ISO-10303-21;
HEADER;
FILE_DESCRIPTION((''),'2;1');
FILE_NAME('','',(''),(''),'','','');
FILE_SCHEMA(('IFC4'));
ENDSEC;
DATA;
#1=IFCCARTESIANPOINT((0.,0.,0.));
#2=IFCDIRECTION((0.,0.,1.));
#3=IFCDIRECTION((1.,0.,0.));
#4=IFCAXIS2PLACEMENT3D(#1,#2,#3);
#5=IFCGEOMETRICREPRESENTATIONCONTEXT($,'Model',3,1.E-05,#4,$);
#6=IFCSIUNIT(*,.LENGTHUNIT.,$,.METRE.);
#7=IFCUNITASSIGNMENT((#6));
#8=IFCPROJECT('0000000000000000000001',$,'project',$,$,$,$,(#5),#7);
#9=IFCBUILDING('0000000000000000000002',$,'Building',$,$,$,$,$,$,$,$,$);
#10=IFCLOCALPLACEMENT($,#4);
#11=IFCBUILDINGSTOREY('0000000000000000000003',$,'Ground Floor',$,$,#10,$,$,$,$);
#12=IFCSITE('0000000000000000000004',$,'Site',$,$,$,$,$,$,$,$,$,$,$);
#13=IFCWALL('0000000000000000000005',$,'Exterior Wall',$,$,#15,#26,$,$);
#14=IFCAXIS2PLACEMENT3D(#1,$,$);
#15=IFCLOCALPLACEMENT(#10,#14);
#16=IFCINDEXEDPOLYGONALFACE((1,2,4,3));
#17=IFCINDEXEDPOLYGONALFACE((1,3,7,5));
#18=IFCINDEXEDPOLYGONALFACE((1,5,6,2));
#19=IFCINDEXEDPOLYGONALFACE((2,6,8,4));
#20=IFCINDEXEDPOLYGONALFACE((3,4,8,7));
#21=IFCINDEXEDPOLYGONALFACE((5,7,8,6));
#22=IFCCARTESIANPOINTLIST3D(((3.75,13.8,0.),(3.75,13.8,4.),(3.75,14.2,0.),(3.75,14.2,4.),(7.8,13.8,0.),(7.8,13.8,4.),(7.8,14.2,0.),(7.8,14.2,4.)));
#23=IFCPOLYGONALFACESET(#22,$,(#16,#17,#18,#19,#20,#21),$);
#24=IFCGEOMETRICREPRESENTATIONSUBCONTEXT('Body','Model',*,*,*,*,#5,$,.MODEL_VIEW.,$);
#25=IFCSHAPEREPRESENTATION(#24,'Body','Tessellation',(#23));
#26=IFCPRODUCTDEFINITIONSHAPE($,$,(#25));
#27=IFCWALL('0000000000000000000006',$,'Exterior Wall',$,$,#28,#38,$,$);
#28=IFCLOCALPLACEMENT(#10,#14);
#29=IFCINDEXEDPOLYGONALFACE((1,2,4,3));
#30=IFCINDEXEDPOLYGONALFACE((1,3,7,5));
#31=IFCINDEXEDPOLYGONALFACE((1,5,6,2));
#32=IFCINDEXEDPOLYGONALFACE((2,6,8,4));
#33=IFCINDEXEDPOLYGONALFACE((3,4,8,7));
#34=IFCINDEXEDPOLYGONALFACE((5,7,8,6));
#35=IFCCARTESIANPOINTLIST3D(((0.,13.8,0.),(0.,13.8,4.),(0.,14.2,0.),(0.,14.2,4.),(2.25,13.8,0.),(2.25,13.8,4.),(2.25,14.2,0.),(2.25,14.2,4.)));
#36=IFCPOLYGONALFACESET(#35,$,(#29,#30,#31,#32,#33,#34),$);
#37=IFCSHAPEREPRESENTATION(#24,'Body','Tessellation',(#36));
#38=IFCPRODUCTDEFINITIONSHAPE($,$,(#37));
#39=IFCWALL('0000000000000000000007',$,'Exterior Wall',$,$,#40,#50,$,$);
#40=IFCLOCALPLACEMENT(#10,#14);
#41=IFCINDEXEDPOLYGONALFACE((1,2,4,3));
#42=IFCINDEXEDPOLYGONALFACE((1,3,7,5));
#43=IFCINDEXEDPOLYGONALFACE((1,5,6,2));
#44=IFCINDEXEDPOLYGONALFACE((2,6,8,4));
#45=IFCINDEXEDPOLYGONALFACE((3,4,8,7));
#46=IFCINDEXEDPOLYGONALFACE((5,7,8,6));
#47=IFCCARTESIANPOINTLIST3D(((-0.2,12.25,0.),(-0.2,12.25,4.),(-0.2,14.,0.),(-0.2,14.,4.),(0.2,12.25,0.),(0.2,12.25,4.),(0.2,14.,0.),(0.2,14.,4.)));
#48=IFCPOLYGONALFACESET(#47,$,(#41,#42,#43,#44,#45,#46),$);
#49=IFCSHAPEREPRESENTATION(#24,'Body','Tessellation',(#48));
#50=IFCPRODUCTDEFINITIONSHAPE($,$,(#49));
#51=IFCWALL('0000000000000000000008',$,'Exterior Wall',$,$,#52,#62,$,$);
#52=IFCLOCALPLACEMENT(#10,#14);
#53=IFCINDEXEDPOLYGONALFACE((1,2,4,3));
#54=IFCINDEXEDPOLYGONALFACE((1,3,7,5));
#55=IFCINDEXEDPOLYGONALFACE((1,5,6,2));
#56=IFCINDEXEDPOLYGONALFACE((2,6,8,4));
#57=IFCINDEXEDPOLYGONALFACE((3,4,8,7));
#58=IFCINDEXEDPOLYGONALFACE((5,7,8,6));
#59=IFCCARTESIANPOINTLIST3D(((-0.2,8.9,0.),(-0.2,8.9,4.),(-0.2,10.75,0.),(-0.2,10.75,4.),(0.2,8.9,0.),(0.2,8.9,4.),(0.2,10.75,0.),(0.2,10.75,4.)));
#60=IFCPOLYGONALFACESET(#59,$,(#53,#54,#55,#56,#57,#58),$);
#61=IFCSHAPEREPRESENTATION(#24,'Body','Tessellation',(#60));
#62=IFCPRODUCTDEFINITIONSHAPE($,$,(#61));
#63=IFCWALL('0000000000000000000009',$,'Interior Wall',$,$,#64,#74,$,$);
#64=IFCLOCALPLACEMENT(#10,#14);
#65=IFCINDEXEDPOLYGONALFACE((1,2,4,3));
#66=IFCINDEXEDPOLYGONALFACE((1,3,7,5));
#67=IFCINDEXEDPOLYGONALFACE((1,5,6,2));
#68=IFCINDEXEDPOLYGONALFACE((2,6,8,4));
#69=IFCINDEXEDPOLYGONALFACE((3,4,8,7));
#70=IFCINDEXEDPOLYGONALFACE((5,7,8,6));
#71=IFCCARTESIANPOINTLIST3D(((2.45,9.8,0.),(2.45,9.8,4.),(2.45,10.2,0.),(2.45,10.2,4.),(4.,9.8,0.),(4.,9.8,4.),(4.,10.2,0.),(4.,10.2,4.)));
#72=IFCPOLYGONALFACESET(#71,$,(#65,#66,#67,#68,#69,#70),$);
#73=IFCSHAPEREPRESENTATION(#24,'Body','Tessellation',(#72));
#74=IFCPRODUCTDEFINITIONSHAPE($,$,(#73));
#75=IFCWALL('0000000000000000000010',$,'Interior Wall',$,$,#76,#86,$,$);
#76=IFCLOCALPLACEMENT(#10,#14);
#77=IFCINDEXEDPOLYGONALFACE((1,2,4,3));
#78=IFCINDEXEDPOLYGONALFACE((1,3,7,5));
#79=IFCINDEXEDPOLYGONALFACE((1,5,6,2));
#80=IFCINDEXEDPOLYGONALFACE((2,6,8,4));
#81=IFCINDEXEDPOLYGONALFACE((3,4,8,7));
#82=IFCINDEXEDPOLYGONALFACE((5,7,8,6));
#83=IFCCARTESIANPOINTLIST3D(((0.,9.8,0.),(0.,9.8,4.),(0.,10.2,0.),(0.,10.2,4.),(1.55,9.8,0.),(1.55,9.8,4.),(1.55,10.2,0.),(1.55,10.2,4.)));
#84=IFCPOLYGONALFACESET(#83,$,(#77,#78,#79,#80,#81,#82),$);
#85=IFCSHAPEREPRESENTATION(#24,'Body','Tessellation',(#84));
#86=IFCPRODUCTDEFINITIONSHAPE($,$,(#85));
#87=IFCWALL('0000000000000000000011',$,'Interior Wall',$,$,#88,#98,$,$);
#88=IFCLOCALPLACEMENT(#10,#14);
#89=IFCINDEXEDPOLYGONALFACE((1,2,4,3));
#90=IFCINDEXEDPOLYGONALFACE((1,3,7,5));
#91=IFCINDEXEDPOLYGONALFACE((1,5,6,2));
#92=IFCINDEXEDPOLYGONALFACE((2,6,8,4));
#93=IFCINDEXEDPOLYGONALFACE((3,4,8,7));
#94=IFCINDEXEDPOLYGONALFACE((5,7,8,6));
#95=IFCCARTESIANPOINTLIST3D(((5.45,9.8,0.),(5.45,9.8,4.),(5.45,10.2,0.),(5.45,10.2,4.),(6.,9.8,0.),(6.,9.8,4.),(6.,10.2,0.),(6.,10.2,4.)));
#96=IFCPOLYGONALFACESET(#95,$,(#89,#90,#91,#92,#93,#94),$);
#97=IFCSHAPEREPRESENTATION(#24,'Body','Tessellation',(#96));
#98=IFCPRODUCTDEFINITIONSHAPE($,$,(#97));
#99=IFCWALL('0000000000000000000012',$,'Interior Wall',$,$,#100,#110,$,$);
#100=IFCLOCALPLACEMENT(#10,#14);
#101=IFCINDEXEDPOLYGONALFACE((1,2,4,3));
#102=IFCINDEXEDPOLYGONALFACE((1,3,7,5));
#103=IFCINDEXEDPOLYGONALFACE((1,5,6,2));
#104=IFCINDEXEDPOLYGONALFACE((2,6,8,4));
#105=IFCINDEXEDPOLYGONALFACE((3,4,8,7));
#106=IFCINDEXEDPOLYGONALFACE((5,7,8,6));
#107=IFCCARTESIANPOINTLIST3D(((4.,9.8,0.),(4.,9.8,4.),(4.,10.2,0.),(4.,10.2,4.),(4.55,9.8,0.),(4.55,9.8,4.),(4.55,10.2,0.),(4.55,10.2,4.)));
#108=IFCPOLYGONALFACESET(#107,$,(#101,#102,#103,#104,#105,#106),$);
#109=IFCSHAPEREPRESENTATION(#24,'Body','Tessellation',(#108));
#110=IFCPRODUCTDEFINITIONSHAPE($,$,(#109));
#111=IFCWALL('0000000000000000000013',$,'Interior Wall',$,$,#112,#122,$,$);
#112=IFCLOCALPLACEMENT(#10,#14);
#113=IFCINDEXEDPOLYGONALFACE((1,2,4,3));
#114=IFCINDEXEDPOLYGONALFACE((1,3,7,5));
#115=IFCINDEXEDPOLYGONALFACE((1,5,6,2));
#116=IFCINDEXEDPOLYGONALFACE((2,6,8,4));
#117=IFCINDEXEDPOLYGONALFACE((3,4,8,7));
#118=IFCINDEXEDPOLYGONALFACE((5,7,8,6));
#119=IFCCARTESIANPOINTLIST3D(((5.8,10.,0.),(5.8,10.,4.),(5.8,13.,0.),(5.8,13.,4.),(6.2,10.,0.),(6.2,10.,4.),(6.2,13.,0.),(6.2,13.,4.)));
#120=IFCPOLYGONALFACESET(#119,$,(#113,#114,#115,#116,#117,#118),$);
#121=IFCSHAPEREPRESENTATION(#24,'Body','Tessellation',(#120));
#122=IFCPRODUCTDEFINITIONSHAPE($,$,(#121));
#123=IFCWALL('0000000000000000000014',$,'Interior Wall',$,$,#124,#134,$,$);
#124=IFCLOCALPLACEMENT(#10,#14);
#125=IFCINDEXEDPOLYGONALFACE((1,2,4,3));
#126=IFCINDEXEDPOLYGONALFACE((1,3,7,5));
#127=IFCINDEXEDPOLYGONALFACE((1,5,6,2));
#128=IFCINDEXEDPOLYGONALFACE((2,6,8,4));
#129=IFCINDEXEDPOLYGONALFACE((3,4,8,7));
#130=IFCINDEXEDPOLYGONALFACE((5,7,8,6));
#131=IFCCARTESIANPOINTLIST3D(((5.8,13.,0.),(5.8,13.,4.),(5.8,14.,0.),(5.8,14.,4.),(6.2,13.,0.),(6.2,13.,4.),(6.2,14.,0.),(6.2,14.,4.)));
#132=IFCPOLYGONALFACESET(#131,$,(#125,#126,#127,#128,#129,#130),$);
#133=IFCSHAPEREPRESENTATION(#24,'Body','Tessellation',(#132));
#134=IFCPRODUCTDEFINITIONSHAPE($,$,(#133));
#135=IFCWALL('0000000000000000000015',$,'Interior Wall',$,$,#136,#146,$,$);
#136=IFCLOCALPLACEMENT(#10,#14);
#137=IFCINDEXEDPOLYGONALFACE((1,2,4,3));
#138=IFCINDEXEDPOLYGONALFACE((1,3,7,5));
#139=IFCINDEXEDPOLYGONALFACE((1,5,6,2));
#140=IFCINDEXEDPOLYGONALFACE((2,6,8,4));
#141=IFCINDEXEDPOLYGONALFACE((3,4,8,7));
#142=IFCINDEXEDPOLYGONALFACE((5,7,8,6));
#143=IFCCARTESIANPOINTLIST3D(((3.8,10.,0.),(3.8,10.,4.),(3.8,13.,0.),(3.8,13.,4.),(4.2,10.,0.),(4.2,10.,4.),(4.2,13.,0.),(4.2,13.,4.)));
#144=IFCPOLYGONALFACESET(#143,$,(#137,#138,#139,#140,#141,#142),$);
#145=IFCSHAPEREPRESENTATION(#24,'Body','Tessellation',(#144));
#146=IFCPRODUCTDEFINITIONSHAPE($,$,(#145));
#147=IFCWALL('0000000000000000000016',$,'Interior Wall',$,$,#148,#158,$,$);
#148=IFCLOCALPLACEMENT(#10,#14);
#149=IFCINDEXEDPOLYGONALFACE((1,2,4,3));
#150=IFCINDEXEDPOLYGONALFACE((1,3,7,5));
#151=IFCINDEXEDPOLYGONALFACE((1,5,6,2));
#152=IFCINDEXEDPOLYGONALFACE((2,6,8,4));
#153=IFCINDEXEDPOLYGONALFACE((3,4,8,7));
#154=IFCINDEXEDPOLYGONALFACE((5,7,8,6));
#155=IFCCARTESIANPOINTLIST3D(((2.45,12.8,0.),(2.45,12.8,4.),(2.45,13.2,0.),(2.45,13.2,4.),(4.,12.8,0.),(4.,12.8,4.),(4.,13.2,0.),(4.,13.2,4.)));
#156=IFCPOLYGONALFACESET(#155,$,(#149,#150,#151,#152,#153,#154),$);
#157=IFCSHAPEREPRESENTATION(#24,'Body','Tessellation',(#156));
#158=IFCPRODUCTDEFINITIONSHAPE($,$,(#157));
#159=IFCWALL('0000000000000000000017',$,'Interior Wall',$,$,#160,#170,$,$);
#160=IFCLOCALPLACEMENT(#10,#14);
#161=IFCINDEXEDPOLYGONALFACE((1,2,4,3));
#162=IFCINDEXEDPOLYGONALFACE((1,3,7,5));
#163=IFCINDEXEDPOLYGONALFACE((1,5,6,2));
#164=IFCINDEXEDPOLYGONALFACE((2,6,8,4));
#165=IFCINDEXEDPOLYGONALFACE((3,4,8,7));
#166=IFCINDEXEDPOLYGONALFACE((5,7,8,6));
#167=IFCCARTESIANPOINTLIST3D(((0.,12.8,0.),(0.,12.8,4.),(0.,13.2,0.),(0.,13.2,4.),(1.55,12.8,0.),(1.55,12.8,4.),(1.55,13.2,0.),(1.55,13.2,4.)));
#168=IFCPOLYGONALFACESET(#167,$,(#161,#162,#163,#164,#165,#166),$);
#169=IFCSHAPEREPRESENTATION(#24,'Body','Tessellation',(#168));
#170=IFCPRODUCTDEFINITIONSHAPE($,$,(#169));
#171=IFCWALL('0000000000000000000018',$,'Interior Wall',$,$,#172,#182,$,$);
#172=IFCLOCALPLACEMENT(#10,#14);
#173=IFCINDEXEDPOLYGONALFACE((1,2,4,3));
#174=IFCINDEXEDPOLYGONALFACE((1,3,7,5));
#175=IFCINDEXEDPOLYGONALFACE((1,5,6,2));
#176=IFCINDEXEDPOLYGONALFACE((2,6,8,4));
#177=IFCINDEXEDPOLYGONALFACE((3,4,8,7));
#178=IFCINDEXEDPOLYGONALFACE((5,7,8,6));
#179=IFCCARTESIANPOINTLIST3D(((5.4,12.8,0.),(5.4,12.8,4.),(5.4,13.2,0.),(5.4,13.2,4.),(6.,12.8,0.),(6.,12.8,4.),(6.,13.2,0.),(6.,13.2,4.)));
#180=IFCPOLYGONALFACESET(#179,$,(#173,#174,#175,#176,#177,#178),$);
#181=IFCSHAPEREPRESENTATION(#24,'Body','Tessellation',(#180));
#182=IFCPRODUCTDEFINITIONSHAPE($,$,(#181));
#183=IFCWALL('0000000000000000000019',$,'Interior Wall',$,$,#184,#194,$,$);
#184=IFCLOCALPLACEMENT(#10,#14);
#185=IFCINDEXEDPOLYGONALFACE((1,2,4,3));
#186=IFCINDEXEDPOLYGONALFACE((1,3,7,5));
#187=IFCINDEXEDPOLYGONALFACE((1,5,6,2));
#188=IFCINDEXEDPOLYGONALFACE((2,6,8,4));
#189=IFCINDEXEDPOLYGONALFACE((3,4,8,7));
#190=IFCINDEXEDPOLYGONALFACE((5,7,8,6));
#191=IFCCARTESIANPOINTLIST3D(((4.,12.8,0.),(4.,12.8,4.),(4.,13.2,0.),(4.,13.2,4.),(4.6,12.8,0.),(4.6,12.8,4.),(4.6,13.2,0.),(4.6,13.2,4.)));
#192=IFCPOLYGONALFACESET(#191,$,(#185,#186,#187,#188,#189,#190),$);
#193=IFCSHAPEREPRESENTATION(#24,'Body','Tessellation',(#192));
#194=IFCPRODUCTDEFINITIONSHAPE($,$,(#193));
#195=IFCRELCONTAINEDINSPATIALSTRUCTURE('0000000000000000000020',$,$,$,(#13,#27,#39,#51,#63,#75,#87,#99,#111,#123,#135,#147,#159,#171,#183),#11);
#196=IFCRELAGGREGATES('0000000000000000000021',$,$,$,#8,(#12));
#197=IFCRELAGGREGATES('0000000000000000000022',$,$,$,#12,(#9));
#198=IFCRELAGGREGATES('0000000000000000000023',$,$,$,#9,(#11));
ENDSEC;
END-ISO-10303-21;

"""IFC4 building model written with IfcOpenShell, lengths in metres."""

from ifc_helpers import new_model, si_unit, frame, origin_with_axes, place, context, subcontext, project, spatial, indexed_curve, outline, extrude, element, save


model = new_model("IFC4")

# Units and contexts
model_context = context("Model", 3, precision=1e-05, world=origin_with_axes())
body_context = subcontext(model_context, "Body", "Model", "MODEL_VIEW")
ifc_project = project(units=[si_unit("LENGTHUNIT", "METRE")], contexts=[model_context])

# Site, building, storey
site = spatial("IfcSite", under=ifc_project, Name="Site")
building = spatial("IfcBuilding", under=site, Name="Building")
storey_placement = place(None, origin_with_axes())
storey = spatial("IfcBuildingStorey", under=building, at=storey_placement, Name="Ground Floor")

# Walls
wall_1_placement = place(storey_placement, frame((7.8, 14.0, 0.0), z_axis=(0.0, 0.0, 1.0), x_axis=(-1.0, 0.0, 0.0)))
element("IfcWall", 1, at=wall_1_placement, inside=storey, Name="Exterior Wall", context=body_context, shape_type="SweptSolid", body=[
    extrude(outline(indexed_curve([(0.0, 0.0), (0.0, 0.4), (4.05, 0.4), (4.05, 0.0), (0.0, 0.0)], self_intersect=False)), frame((0.0, -0.2, 0.0), z_axis=(0.0, 0.0, 1.0), x_axis=(1.0, 0.0, 0.0)), (0.0, 0.0, 1.0), 4.0),
])
wall_2_placement = place(storey_placement, frame((2.25, 14.0, 0.0), z_axis=(0.0, 0.0, 1.0), x_axis=(-1.0, 0.0, 0.0)))
element("IfcWall", 2, at=wall_2_placement, inside=storey, Name="Exterior Wall", context=body_context, shape_type="SweptSolid", body=[
    extrude(outline(indexed_curve([(0.0, 0.0), (0.0, 0.4), (2.25, 0.4), (2.25, 0.0), (0.0, 0.0)], self_intersect=False)), frame((0.0, -0.2, 0.0), z_axis=(0.0, 0.0, 1.0), x_axis=(1.0, 0.0, 0.0)), (0.0, 0.0, 1.0), 4.0),
])
wall_3_placement = place(storey_placement, frame((0.0, 14.0, 0.0), z_axis=(0.0, 0.0, 1.0), x_axis=(0.0, -1.0, 0.0)))
element("IfcWall", 3, at=wall_3_placement, inside=storey, Name="Exterior Wall", context=body_context, shape_type="SweptSolid", body=[
    extrude(outline(indexed_curve([(0.0, 0.0), (0.0, 0.4), (1.75, 0.4), (1.75, 0.0), (0.0, 0.0)], self_intersect=False)), frame((0.0, -0.2, 0.0), z_axis=(0.0, 0.0, 1.0), x_axis=(1.0, 0.0, 0.0)), (0.0, 0.0, 1.0), 4.0),
])
wall_4_placement = place(storey_placement, frame((0.0, 10.75, 0.0), z_axis=(0.0, 0.0, 1.0), x_axis=(0.0, -1.0, 0.0)))
element("IfcWall", 4, at=wall_4_placement, inside=storey, Name="Exterior Wall", context=body_context, shape_type="SweptSolid", body=[
    extrude(outline(indexed_curve([(0.0, 0.0), (0.0, 0.4), (1.85, 0.4), (1.85, 0.0), (0.0, 0.0)], self_intersect=False)), frame((0.0, -0.2, 0.0), z_axis=(0.0, 0.0, 1.0), x_axis=(1.0, 0.0, 0.0)), (0.0, 0.0, 1.0), 4.0),
])
for number, where, z_axis, x_axis, name in (
    (5, (4.0, 10.0, 0.0), (0.0, 0.0, 1.0), (-1.0, 0.0, 0.0), "Interior Wall"),
    (6, (1.55, 10.0, 0.0), (0.0, 0.0, 1.0), (-1.0, 0.0, 0.0), "Interior Wall"),
):
    element("IfcWall", number, at=place(storey_placement, frame(where, z_axis=z_axis, x_axis=x_axis)), inside=storey, Name=name, context=body_context, shape_type="SweptSolid", body=[
        extrude(outline(indexed_curve([(0.0, 0.0), (0.0, 0.4), (1.55, 0.4), (1.55, 0.0), (0.0, 0.0)], self_intersect=False)), frame((0.0, -0.2, 0.0), z_axis=(0.0, 0.0, 1.0), x_axis=(1.0, 0.0, 0.0)), (0.0, 0.0, 1.0), 4.0),
    ])
for number, where, z_axis, x_axis, name in (
    (7, (6.0, 10.0, 0.0), (0.0, 0.0, 1.0), (-1.0, 0.0, 0.0), "Interior Wall"),
    (8, (4.55, 10.0, 0.0), (0.0, 0.0, 1.0), (-1.0, 0.0, 0.0), "Interior Wall"),
):
    element("IfcWall", number, at=place(storey_placement, frame(where, z_axis=z_axis, x_axis=x_axis)), inside=storey, Name=name, context=body_context, shape_type="SweptSolid", body=[
        extrude(outline(indexed_curve([(0.0, 0.0), (0.0, 0.4), (0.55, 0.4), (0.55, 0.0), (0.0, 0.0)], self_intersect=False)), frame((0.0, -0.2, 0.0), z_axis=(0.0, 0.0, 1.0), x_axis=(1.0, 0.0, 0.0)), (0.0, 0.0, 1.0), 4.0),
    ])
wall_5_placement = place(storey_placement, frame((6.0, 13.0, 0.0), z_axis=(0.0, 0.0, 1.0), x_axis=(0.0, -1.0, 0.0)))
element("IfcWall", 9, at=wall_5_placement, inside=storey, Name="Interior Wall", context=body_context, shape_type="SweptSolid", body=[
    extrude(outline(indexed_curve([(0.0, 0.0), (0.0, 0.4), (3.0, 0.4), (3.0, 0.0), (0.0, 0.0)], self_intersect=False)), frame((0.0, -0.2, 0.0), z_axis=(0.0, 0.0, 1.0), x_axis=(1.0, 0.0, 0.0)), (0.0, 0.0, 1.0), 4.0),
])
wall_6_placement = place(storey_placement, frame((6.0, 14.0, 0.0), z_axis=(0.0, 0.0, 1.0), x_axis=(0.0, -1.0, 0.0)))
element("IfcWall", 10, at=wall_6_placement, inside=storey, Name="Interior Wall", context=body_context, shape_type="SweptSolid", body=[
    extrude(outline(indexed_curve([(0.0, 0.0), (0.0, 0.4), (1.0, 0.4), (1.0, 0.0), (0.0, 0.0)], self_intersect=False)), frame((0.0, -0.2, 0.0), z_axis=(0.0, 0.0, 1.0), x_axis=(1.0, 0.0, 0.0)), (0.0, 0.0, 1.0), 4.0),
])
wall_7_placement = place(storey_placement, frame((4.0, 10.0, 0.0), z_axis=(0.0, 0.0, 1.0), x_axis=(0.0, 1.0, 0.0)))
element("IfcWall", 11, at=wall_7_placement, inside=storey, Name="Interior Wall", context=body_context, shape_type="SweptSolid", body=[
    extrude(outline(indexed_curve([(0.0, 0.0), (0.0, 0.4), (3.0, 0.4), (3.0, 0.0), (0.0, 0.0)], self_intersect=False)), frame((0.0, -0.2, 0.0), z_axis=(0.0, 0.0, 1.0), x_axis=(1.0, 0.0, 0.0)), (0.0, 0.0, 1.0), 4.0),
])
for number, where, z_axis, x_axis, name in (
    (12, (4.0, 13.0, 0.0), (0.0, 0.0, 1.0), (-1.0, 0.0, 0.0), "Interior Wall"),
    (13, (1.55, 13.0, 0.0), (0.0, 0.0, 1.0), (-1.0, 0.0, 0.0), "Interior Wall"),
):
    element("IfcWall", number, at=place(storey_placement, frame(where, z_axis=z_axis, x_axis=x_axis)), inside=storey, Name=name, context=body_context, shape_type="SweptSolid", body=[
        extrude(outline(indexed_curve([(0.0, 0.0), (0.0, 0.4), (1.55, 0.4), (1.55, 0.0), (0.0, 0.0)], self_intersect=False)), frame((0.0, -0.2, 0.0), z_axis=(0.0, 0.0, 1.0), x_axis=(1.0, 0.0, 0.0)), (0.0, 0.0, 1.0), 4.0),
    ])
for number, where, z_axis, x_axis, name in (
    (14, (6.0, 13.0, 0.0), (0.0, 0.0, 1.0), (-1.0, 0.0, 0.0), "Interior Wall"),
    (15, (4.6, 13.0, 0.0), (0.0, 0.0, 1.0), (-1.0, 0.0, 0.0), "Interior Wall"),
):
    element("IfcWall", number, at=place(storey_placement, frame(where, z_axis=z_axis, x_axis=x_axis)), inside=storey, Name=name, context=body_context, shape_type="SweptSolid", body=[
        extrude(outline(indexed_curve([(0.0, 0.0), (0.0, 0.4), (0.6, 0.4), (0.6, 0.0), (0.0, 0.0)], self_intersect=False)), frame((0.0, -0.2, 0.0), z_axis=(0.0, 0.0, 1.0), x_axis=(1.0, 0.0, 0.0)), (0.0, 0.0, 1.0), 4.0),
    ])

save(model, "model.ifc")
